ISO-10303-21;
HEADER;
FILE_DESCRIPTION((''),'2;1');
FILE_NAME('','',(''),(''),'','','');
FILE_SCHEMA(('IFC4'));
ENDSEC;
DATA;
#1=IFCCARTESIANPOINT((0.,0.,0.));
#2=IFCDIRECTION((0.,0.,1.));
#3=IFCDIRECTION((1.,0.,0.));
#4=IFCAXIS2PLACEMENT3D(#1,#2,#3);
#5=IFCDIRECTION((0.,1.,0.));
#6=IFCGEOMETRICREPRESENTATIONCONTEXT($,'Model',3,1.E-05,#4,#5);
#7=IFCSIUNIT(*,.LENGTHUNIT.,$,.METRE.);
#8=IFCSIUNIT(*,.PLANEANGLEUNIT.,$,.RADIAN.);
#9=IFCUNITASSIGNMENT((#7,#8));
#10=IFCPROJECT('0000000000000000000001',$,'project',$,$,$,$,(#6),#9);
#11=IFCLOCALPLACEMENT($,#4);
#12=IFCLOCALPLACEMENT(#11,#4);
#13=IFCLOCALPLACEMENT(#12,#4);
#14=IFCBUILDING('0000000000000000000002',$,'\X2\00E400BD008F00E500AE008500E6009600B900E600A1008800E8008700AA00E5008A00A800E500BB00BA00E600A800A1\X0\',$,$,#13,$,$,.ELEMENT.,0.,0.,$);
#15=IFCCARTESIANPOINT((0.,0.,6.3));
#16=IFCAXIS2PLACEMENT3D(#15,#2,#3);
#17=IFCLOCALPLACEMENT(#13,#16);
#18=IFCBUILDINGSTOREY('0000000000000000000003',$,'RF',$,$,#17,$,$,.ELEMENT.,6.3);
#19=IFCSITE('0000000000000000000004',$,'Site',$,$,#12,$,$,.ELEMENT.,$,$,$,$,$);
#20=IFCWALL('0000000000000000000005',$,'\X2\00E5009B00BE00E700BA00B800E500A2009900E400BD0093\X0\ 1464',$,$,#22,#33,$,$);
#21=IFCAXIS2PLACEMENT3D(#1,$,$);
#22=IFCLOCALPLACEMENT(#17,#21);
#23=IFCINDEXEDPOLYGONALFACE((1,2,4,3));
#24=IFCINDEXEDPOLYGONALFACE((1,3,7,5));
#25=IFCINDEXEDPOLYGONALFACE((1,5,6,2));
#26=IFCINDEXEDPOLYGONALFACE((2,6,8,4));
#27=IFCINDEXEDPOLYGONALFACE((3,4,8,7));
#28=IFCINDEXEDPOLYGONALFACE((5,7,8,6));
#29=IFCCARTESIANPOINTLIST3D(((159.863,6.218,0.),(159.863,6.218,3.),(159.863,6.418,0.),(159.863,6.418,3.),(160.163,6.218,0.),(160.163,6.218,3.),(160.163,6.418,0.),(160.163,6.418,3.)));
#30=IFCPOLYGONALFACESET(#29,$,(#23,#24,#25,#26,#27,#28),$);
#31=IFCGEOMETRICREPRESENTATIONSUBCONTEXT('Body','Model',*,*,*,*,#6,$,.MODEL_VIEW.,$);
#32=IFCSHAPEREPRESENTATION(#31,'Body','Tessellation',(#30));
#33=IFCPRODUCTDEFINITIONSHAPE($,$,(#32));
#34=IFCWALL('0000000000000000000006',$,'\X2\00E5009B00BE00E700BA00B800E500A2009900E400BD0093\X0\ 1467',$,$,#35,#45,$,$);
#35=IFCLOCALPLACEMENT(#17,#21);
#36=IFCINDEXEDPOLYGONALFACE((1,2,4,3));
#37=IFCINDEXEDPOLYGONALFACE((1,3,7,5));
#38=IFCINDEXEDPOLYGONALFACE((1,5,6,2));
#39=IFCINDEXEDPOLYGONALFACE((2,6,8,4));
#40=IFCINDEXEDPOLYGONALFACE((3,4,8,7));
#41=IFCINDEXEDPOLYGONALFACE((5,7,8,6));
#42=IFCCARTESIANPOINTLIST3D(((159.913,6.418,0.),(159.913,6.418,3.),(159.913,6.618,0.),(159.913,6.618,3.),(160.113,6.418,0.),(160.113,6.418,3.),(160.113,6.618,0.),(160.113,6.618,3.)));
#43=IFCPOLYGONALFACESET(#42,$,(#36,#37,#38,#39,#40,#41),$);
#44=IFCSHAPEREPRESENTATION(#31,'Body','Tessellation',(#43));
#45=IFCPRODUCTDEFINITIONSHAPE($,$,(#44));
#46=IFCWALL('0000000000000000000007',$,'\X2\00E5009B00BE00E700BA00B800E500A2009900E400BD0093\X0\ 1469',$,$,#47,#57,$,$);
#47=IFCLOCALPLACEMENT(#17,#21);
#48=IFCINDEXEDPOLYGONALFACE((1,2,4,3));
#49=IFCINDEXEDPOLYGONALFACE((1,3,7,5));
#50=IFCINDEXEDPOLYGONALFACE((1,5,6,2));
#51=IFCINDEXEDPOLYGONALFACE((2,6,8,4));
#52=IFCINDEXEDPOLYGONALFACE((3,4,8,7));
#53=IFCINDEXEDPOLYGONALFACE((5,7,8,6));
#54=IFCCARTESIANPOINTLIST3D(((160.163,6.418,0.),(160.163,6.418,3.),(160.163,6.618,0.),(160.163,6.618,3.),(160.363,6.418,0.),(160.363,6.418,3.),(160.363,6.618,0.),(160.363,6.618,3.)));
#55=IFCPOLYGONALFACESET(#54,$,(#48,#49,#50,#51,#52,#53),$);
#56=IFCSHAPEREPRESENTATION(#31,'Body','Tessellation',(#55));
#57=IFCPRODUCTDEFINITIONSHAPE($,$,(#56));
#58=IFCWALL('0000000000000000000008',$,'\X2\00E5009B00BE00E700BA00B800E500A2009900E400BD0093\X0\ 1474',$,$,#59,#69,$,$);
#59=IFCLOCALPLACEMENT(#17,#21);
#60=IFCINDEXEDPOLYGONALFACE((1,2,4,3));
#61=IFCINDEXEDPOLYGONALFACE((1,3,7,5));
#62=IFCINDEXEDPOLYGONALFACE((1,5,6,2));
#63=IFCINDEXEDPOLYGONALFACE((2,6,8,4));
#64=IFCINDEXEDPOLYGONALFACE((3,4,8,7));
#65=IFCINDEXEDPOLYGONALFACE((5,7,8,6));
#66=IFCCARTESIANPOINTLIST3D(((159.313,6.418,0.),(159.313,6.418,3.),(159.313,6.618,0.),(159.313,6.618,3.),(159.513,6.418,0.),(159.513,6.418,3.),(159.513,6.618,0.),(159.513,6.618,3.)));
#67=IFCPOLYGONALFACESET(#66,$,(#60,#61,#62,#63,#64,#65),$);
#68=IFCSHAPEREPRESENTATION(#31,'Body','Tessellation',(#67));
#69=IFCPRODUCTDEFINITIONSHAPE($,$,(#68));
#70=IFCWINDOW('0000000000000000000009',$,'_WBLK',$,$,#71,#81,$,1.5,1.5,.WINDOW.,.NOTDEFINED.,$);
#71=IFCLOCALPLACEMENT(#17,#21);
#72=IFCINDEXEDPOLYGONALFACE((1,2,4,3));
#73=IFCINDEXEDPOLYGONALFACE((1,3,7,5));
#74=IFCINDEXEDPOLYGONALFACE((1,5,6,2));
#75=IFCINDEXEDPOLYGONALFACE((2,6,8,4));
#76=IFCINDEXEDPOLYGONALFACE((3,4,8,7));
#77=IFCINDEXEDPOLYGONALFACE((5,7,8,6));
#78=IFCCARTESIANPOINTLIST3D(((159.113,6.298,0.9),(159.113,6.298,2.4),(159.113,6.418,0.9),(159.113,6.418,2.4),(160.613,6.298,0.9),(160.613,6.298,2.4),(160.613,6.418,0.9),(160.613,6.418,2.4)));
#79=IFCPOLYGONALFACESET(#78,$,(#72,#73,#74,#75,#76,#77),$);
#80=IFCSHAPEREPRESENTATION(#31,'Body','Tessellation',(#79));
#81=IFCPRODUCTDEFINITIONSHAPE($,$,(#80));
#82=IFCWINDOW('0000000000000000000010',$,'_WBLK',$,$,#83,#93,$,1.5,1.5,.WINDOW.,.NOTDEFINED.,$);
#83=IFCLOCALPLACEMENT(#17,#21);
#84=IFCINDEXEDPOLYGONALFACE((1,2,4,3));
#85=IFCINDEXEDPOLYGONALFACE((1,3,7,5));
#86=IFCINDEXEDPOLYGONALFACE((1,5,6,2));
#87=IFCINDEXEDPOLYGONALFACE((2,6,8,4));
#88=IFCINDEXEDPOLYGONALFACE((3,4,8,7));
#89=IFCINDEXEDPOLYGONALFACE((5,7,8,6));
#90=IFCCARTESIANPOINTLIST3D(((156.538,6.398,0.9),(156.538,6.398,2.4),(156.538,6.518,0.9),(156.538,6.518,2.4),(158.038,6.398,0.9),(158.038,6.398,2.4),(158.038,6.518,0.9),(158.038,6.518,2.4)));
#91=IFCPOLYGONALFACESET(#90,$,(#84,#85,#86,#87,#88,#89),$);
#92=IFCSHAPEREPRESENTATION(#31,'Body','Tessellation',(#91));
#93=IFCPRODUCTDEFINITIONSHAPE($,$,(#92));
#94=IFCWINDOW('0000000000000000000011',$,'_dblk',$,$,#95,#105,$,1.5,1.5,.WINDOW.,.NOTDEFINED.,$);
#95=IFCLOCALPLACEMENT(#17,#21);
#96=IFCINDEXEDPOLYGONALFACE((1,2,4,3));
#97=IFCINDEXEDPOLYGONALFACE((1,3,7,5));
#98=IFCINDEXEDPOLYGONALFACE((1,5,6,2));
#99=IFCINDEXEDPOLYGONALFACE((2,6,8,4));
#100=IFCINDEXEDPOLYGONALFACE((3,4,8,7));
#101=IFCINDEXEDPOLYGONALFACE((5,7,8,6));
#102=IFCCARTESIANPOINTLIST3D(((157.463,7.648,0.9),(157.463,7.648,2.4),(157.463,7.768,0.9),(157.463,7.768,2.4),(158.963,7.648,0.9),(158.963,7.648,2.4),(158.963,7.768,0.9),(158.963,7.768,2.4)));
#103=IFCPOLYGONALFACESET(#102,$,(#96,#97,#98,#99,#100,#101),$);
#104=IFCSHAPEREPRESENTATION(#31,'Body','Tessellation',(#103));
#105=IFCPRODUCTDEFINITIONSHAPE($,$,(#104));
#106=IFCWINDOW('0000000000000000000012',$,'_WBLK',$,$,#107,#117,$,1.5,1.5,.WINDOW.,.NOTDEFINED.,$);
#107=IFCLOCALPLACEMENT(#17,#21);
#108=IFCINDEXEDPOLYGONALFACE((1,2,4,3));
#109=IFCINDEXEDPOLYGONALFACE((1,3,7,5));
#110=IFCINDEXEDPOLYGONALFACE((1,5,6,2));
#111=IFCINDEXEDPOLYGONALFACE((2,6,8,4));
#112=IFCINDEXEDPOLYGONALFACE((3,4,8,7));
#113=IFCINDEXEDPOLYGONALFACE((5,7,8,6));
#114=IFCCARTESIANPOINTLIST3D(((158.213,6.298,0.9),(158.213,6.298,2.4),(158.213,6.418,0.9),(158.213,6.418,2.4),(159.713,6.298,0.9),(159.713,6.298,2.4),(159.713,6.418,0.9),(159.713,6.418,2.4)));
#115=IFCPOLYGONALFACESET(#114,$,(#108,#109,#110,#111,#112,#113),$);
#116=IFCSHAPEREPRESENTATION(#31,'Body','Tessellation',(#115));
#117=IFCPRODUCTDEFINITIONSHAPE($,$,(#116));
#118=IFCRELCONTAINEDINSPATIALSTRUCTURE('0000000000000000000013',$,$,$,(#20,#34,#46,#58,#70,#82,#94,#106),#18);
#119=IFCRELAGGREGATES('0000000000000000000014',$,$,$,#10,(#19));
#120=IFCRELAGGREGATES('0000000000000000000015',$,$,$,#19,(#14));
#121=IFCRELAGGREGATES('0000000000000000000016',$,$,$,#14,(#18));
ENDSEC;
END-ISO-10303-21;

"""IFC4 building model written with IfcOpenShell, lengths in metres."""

from ifc_helpers import new_model, si_unit, direction, frame, frame_2d, origin_with_axes, place, context, subcontext, project, spatial, rectangle, extrude, element, save


model = new_model("IFC4")

# Units and contexts
model_context = context("Model", 3, precision=1e-05, world=origin_with_axes(), true_north=direction((0.0, 1.0, 0.0)))
body_context = subcontext(model_context, "Body", "Model", "MODEL_VIEW")
ifc_project = project(units=[si_unit("LENGTHUNIT", "METRE"), si_unit("PLANEANGLEUNIT", "RADIAN")], contexts=[model_context])

# Site, building, storey
placement = place(None, origin_with_axes())
site_placement = place(placement, origin_with_axes())
site = spatial("IfcSite", under=ifc_project, at=site_placement, Name="Site", CompositionType="ELEMENT")
building_placement = place(site_placement, origin_with_axes())
building = spatial("IfcBuilding", under=site, at=building_placement, Name="ä½\u008få®\u0085æ\u0096¹æ¡\u0088è\u0087ªå\u008a¨å»ºæ¨¡", CompositionType="ELEMENT", ElevationOfRefHeight=0.0, ElevationOfTerrain=0.0)
storey_placement = place(building_placement, frame((0.0, 0.0, 6.3), z_axis=(0.0, 0.0, 1.0), x_axis=(1.0, 0.0, 0.0)))
storey = spatial("IfcBuildingStorey", under=building, at=storey_placement, Name="RF", CompositionType="ELEMENT", Elevation=6.3)

# Walls
wall_1_placement = place(storey_placement, frame((160.013, 6.318, 0.0), z_axis=(0.0, 0.0, 1.0), x_axis=(1.0, 0.0, 0.0)))
element("IfcWall", 1, at=wall_1_placement, inside=storey, Name="å\u009b¾çº¸å¢\u0099ä½\u0093 1464", context=body_context, shape_type="SweptSolid", body=[
    extrude(rectangle(XDim=0.3, YDim=0.2, at=frame_2d((0.0, 0.0), x_axis=(1.0, 0.0, 0.0))), frame((0.0, 0.0, 0.0), z_axis=(0.0, 0.0, 1.0)), (0.0, 0.0, 1.0), 3.0),
])
for number, where, z_axis, x_axis, name in (
    (2, (160.013, 6.518, 0.0), (0.0, 0.0, 1.0), (1.0, 0.0, 0.0), "å\u009b¾çº¸å¢\u0099ä½\u0093 1467"),
    (3, (160.263, 6.518, 0.0), (0.0, 0.0, 1.0), (1.0, 0.0, 0.0), "å\u009b¾çº¸å¢\u0099ä½\u0093 1469"),
    (4, (159.413, 6.518, 0.0), (0.0, 0.0, 1.0), (0.0, -1.0, 0.0), "å\u009b¾çº¸å¢\u0099ä½\u0093 1474"),
):
    element("IfcWall", number, at=place(storey_placement, frame(where, z_axis=z_axis, x_axis=x_axis)), inside=storey, Name=name, context=body_context, shape_type="SweptSolid", body=[
        extrude(rectangle(XDim=0.2, YDim=0.2, at=frame_2d((0.0, 0.0), x_axis=(1.0, 0.0, 0.0))), frame((0.0, 0.0, 0.0), z_axis=(0.0, 0.0, 1.0)), (0.0, 0.0, 1.0), 3.0),
    ])

# Windows
for number, where, z_axis, x_axis, name in (
    (5, (159.863, 6.358, 0.9), (0.0, 0.0, 1.0), (1.0, 0.0, 0.0), "_WBLK"),
    (6, (157.288, 6.458, 0.9), (0.0, 0.0, 1.0), (1.0, 0.0, 0.0), "_WBLK"),
    (7, (158.213, 7.708, 0.9), (0.0, 0.0, 1.0), (1.0, 0.0, 0.0), "_dblk"),
    (8, (158.963, 6.358, 0.9), (0.0, 0.0, 1.0), (1.0, 0.0, 0.0), "_WBLK"),
):
    element("IfcWindow", number, at=place(storey_placement, frame(where, z_axis=z_axis, x_axis=x_axis)), inside=storey, Name=name, OverallHeight=1.5, OverallWidth=1.5, PartitioningType="NOTDEFINED", PredefinedType="WINDOW", context=body_context, shape_type="SweptSolid", body=[
        extrude(rectangle(XDim=1.5, YDim=0.12, at=frame_2d((0.0, 0.0), x_axis=(1.0, 0.0, 0.0))), frame((0.0, 0.0, 0.0), z_axis=(0.0, 0.0, 1.0)), (0.0, 0.0, 1.0), 1.5),
    ])

save(model, "model.ifc")
